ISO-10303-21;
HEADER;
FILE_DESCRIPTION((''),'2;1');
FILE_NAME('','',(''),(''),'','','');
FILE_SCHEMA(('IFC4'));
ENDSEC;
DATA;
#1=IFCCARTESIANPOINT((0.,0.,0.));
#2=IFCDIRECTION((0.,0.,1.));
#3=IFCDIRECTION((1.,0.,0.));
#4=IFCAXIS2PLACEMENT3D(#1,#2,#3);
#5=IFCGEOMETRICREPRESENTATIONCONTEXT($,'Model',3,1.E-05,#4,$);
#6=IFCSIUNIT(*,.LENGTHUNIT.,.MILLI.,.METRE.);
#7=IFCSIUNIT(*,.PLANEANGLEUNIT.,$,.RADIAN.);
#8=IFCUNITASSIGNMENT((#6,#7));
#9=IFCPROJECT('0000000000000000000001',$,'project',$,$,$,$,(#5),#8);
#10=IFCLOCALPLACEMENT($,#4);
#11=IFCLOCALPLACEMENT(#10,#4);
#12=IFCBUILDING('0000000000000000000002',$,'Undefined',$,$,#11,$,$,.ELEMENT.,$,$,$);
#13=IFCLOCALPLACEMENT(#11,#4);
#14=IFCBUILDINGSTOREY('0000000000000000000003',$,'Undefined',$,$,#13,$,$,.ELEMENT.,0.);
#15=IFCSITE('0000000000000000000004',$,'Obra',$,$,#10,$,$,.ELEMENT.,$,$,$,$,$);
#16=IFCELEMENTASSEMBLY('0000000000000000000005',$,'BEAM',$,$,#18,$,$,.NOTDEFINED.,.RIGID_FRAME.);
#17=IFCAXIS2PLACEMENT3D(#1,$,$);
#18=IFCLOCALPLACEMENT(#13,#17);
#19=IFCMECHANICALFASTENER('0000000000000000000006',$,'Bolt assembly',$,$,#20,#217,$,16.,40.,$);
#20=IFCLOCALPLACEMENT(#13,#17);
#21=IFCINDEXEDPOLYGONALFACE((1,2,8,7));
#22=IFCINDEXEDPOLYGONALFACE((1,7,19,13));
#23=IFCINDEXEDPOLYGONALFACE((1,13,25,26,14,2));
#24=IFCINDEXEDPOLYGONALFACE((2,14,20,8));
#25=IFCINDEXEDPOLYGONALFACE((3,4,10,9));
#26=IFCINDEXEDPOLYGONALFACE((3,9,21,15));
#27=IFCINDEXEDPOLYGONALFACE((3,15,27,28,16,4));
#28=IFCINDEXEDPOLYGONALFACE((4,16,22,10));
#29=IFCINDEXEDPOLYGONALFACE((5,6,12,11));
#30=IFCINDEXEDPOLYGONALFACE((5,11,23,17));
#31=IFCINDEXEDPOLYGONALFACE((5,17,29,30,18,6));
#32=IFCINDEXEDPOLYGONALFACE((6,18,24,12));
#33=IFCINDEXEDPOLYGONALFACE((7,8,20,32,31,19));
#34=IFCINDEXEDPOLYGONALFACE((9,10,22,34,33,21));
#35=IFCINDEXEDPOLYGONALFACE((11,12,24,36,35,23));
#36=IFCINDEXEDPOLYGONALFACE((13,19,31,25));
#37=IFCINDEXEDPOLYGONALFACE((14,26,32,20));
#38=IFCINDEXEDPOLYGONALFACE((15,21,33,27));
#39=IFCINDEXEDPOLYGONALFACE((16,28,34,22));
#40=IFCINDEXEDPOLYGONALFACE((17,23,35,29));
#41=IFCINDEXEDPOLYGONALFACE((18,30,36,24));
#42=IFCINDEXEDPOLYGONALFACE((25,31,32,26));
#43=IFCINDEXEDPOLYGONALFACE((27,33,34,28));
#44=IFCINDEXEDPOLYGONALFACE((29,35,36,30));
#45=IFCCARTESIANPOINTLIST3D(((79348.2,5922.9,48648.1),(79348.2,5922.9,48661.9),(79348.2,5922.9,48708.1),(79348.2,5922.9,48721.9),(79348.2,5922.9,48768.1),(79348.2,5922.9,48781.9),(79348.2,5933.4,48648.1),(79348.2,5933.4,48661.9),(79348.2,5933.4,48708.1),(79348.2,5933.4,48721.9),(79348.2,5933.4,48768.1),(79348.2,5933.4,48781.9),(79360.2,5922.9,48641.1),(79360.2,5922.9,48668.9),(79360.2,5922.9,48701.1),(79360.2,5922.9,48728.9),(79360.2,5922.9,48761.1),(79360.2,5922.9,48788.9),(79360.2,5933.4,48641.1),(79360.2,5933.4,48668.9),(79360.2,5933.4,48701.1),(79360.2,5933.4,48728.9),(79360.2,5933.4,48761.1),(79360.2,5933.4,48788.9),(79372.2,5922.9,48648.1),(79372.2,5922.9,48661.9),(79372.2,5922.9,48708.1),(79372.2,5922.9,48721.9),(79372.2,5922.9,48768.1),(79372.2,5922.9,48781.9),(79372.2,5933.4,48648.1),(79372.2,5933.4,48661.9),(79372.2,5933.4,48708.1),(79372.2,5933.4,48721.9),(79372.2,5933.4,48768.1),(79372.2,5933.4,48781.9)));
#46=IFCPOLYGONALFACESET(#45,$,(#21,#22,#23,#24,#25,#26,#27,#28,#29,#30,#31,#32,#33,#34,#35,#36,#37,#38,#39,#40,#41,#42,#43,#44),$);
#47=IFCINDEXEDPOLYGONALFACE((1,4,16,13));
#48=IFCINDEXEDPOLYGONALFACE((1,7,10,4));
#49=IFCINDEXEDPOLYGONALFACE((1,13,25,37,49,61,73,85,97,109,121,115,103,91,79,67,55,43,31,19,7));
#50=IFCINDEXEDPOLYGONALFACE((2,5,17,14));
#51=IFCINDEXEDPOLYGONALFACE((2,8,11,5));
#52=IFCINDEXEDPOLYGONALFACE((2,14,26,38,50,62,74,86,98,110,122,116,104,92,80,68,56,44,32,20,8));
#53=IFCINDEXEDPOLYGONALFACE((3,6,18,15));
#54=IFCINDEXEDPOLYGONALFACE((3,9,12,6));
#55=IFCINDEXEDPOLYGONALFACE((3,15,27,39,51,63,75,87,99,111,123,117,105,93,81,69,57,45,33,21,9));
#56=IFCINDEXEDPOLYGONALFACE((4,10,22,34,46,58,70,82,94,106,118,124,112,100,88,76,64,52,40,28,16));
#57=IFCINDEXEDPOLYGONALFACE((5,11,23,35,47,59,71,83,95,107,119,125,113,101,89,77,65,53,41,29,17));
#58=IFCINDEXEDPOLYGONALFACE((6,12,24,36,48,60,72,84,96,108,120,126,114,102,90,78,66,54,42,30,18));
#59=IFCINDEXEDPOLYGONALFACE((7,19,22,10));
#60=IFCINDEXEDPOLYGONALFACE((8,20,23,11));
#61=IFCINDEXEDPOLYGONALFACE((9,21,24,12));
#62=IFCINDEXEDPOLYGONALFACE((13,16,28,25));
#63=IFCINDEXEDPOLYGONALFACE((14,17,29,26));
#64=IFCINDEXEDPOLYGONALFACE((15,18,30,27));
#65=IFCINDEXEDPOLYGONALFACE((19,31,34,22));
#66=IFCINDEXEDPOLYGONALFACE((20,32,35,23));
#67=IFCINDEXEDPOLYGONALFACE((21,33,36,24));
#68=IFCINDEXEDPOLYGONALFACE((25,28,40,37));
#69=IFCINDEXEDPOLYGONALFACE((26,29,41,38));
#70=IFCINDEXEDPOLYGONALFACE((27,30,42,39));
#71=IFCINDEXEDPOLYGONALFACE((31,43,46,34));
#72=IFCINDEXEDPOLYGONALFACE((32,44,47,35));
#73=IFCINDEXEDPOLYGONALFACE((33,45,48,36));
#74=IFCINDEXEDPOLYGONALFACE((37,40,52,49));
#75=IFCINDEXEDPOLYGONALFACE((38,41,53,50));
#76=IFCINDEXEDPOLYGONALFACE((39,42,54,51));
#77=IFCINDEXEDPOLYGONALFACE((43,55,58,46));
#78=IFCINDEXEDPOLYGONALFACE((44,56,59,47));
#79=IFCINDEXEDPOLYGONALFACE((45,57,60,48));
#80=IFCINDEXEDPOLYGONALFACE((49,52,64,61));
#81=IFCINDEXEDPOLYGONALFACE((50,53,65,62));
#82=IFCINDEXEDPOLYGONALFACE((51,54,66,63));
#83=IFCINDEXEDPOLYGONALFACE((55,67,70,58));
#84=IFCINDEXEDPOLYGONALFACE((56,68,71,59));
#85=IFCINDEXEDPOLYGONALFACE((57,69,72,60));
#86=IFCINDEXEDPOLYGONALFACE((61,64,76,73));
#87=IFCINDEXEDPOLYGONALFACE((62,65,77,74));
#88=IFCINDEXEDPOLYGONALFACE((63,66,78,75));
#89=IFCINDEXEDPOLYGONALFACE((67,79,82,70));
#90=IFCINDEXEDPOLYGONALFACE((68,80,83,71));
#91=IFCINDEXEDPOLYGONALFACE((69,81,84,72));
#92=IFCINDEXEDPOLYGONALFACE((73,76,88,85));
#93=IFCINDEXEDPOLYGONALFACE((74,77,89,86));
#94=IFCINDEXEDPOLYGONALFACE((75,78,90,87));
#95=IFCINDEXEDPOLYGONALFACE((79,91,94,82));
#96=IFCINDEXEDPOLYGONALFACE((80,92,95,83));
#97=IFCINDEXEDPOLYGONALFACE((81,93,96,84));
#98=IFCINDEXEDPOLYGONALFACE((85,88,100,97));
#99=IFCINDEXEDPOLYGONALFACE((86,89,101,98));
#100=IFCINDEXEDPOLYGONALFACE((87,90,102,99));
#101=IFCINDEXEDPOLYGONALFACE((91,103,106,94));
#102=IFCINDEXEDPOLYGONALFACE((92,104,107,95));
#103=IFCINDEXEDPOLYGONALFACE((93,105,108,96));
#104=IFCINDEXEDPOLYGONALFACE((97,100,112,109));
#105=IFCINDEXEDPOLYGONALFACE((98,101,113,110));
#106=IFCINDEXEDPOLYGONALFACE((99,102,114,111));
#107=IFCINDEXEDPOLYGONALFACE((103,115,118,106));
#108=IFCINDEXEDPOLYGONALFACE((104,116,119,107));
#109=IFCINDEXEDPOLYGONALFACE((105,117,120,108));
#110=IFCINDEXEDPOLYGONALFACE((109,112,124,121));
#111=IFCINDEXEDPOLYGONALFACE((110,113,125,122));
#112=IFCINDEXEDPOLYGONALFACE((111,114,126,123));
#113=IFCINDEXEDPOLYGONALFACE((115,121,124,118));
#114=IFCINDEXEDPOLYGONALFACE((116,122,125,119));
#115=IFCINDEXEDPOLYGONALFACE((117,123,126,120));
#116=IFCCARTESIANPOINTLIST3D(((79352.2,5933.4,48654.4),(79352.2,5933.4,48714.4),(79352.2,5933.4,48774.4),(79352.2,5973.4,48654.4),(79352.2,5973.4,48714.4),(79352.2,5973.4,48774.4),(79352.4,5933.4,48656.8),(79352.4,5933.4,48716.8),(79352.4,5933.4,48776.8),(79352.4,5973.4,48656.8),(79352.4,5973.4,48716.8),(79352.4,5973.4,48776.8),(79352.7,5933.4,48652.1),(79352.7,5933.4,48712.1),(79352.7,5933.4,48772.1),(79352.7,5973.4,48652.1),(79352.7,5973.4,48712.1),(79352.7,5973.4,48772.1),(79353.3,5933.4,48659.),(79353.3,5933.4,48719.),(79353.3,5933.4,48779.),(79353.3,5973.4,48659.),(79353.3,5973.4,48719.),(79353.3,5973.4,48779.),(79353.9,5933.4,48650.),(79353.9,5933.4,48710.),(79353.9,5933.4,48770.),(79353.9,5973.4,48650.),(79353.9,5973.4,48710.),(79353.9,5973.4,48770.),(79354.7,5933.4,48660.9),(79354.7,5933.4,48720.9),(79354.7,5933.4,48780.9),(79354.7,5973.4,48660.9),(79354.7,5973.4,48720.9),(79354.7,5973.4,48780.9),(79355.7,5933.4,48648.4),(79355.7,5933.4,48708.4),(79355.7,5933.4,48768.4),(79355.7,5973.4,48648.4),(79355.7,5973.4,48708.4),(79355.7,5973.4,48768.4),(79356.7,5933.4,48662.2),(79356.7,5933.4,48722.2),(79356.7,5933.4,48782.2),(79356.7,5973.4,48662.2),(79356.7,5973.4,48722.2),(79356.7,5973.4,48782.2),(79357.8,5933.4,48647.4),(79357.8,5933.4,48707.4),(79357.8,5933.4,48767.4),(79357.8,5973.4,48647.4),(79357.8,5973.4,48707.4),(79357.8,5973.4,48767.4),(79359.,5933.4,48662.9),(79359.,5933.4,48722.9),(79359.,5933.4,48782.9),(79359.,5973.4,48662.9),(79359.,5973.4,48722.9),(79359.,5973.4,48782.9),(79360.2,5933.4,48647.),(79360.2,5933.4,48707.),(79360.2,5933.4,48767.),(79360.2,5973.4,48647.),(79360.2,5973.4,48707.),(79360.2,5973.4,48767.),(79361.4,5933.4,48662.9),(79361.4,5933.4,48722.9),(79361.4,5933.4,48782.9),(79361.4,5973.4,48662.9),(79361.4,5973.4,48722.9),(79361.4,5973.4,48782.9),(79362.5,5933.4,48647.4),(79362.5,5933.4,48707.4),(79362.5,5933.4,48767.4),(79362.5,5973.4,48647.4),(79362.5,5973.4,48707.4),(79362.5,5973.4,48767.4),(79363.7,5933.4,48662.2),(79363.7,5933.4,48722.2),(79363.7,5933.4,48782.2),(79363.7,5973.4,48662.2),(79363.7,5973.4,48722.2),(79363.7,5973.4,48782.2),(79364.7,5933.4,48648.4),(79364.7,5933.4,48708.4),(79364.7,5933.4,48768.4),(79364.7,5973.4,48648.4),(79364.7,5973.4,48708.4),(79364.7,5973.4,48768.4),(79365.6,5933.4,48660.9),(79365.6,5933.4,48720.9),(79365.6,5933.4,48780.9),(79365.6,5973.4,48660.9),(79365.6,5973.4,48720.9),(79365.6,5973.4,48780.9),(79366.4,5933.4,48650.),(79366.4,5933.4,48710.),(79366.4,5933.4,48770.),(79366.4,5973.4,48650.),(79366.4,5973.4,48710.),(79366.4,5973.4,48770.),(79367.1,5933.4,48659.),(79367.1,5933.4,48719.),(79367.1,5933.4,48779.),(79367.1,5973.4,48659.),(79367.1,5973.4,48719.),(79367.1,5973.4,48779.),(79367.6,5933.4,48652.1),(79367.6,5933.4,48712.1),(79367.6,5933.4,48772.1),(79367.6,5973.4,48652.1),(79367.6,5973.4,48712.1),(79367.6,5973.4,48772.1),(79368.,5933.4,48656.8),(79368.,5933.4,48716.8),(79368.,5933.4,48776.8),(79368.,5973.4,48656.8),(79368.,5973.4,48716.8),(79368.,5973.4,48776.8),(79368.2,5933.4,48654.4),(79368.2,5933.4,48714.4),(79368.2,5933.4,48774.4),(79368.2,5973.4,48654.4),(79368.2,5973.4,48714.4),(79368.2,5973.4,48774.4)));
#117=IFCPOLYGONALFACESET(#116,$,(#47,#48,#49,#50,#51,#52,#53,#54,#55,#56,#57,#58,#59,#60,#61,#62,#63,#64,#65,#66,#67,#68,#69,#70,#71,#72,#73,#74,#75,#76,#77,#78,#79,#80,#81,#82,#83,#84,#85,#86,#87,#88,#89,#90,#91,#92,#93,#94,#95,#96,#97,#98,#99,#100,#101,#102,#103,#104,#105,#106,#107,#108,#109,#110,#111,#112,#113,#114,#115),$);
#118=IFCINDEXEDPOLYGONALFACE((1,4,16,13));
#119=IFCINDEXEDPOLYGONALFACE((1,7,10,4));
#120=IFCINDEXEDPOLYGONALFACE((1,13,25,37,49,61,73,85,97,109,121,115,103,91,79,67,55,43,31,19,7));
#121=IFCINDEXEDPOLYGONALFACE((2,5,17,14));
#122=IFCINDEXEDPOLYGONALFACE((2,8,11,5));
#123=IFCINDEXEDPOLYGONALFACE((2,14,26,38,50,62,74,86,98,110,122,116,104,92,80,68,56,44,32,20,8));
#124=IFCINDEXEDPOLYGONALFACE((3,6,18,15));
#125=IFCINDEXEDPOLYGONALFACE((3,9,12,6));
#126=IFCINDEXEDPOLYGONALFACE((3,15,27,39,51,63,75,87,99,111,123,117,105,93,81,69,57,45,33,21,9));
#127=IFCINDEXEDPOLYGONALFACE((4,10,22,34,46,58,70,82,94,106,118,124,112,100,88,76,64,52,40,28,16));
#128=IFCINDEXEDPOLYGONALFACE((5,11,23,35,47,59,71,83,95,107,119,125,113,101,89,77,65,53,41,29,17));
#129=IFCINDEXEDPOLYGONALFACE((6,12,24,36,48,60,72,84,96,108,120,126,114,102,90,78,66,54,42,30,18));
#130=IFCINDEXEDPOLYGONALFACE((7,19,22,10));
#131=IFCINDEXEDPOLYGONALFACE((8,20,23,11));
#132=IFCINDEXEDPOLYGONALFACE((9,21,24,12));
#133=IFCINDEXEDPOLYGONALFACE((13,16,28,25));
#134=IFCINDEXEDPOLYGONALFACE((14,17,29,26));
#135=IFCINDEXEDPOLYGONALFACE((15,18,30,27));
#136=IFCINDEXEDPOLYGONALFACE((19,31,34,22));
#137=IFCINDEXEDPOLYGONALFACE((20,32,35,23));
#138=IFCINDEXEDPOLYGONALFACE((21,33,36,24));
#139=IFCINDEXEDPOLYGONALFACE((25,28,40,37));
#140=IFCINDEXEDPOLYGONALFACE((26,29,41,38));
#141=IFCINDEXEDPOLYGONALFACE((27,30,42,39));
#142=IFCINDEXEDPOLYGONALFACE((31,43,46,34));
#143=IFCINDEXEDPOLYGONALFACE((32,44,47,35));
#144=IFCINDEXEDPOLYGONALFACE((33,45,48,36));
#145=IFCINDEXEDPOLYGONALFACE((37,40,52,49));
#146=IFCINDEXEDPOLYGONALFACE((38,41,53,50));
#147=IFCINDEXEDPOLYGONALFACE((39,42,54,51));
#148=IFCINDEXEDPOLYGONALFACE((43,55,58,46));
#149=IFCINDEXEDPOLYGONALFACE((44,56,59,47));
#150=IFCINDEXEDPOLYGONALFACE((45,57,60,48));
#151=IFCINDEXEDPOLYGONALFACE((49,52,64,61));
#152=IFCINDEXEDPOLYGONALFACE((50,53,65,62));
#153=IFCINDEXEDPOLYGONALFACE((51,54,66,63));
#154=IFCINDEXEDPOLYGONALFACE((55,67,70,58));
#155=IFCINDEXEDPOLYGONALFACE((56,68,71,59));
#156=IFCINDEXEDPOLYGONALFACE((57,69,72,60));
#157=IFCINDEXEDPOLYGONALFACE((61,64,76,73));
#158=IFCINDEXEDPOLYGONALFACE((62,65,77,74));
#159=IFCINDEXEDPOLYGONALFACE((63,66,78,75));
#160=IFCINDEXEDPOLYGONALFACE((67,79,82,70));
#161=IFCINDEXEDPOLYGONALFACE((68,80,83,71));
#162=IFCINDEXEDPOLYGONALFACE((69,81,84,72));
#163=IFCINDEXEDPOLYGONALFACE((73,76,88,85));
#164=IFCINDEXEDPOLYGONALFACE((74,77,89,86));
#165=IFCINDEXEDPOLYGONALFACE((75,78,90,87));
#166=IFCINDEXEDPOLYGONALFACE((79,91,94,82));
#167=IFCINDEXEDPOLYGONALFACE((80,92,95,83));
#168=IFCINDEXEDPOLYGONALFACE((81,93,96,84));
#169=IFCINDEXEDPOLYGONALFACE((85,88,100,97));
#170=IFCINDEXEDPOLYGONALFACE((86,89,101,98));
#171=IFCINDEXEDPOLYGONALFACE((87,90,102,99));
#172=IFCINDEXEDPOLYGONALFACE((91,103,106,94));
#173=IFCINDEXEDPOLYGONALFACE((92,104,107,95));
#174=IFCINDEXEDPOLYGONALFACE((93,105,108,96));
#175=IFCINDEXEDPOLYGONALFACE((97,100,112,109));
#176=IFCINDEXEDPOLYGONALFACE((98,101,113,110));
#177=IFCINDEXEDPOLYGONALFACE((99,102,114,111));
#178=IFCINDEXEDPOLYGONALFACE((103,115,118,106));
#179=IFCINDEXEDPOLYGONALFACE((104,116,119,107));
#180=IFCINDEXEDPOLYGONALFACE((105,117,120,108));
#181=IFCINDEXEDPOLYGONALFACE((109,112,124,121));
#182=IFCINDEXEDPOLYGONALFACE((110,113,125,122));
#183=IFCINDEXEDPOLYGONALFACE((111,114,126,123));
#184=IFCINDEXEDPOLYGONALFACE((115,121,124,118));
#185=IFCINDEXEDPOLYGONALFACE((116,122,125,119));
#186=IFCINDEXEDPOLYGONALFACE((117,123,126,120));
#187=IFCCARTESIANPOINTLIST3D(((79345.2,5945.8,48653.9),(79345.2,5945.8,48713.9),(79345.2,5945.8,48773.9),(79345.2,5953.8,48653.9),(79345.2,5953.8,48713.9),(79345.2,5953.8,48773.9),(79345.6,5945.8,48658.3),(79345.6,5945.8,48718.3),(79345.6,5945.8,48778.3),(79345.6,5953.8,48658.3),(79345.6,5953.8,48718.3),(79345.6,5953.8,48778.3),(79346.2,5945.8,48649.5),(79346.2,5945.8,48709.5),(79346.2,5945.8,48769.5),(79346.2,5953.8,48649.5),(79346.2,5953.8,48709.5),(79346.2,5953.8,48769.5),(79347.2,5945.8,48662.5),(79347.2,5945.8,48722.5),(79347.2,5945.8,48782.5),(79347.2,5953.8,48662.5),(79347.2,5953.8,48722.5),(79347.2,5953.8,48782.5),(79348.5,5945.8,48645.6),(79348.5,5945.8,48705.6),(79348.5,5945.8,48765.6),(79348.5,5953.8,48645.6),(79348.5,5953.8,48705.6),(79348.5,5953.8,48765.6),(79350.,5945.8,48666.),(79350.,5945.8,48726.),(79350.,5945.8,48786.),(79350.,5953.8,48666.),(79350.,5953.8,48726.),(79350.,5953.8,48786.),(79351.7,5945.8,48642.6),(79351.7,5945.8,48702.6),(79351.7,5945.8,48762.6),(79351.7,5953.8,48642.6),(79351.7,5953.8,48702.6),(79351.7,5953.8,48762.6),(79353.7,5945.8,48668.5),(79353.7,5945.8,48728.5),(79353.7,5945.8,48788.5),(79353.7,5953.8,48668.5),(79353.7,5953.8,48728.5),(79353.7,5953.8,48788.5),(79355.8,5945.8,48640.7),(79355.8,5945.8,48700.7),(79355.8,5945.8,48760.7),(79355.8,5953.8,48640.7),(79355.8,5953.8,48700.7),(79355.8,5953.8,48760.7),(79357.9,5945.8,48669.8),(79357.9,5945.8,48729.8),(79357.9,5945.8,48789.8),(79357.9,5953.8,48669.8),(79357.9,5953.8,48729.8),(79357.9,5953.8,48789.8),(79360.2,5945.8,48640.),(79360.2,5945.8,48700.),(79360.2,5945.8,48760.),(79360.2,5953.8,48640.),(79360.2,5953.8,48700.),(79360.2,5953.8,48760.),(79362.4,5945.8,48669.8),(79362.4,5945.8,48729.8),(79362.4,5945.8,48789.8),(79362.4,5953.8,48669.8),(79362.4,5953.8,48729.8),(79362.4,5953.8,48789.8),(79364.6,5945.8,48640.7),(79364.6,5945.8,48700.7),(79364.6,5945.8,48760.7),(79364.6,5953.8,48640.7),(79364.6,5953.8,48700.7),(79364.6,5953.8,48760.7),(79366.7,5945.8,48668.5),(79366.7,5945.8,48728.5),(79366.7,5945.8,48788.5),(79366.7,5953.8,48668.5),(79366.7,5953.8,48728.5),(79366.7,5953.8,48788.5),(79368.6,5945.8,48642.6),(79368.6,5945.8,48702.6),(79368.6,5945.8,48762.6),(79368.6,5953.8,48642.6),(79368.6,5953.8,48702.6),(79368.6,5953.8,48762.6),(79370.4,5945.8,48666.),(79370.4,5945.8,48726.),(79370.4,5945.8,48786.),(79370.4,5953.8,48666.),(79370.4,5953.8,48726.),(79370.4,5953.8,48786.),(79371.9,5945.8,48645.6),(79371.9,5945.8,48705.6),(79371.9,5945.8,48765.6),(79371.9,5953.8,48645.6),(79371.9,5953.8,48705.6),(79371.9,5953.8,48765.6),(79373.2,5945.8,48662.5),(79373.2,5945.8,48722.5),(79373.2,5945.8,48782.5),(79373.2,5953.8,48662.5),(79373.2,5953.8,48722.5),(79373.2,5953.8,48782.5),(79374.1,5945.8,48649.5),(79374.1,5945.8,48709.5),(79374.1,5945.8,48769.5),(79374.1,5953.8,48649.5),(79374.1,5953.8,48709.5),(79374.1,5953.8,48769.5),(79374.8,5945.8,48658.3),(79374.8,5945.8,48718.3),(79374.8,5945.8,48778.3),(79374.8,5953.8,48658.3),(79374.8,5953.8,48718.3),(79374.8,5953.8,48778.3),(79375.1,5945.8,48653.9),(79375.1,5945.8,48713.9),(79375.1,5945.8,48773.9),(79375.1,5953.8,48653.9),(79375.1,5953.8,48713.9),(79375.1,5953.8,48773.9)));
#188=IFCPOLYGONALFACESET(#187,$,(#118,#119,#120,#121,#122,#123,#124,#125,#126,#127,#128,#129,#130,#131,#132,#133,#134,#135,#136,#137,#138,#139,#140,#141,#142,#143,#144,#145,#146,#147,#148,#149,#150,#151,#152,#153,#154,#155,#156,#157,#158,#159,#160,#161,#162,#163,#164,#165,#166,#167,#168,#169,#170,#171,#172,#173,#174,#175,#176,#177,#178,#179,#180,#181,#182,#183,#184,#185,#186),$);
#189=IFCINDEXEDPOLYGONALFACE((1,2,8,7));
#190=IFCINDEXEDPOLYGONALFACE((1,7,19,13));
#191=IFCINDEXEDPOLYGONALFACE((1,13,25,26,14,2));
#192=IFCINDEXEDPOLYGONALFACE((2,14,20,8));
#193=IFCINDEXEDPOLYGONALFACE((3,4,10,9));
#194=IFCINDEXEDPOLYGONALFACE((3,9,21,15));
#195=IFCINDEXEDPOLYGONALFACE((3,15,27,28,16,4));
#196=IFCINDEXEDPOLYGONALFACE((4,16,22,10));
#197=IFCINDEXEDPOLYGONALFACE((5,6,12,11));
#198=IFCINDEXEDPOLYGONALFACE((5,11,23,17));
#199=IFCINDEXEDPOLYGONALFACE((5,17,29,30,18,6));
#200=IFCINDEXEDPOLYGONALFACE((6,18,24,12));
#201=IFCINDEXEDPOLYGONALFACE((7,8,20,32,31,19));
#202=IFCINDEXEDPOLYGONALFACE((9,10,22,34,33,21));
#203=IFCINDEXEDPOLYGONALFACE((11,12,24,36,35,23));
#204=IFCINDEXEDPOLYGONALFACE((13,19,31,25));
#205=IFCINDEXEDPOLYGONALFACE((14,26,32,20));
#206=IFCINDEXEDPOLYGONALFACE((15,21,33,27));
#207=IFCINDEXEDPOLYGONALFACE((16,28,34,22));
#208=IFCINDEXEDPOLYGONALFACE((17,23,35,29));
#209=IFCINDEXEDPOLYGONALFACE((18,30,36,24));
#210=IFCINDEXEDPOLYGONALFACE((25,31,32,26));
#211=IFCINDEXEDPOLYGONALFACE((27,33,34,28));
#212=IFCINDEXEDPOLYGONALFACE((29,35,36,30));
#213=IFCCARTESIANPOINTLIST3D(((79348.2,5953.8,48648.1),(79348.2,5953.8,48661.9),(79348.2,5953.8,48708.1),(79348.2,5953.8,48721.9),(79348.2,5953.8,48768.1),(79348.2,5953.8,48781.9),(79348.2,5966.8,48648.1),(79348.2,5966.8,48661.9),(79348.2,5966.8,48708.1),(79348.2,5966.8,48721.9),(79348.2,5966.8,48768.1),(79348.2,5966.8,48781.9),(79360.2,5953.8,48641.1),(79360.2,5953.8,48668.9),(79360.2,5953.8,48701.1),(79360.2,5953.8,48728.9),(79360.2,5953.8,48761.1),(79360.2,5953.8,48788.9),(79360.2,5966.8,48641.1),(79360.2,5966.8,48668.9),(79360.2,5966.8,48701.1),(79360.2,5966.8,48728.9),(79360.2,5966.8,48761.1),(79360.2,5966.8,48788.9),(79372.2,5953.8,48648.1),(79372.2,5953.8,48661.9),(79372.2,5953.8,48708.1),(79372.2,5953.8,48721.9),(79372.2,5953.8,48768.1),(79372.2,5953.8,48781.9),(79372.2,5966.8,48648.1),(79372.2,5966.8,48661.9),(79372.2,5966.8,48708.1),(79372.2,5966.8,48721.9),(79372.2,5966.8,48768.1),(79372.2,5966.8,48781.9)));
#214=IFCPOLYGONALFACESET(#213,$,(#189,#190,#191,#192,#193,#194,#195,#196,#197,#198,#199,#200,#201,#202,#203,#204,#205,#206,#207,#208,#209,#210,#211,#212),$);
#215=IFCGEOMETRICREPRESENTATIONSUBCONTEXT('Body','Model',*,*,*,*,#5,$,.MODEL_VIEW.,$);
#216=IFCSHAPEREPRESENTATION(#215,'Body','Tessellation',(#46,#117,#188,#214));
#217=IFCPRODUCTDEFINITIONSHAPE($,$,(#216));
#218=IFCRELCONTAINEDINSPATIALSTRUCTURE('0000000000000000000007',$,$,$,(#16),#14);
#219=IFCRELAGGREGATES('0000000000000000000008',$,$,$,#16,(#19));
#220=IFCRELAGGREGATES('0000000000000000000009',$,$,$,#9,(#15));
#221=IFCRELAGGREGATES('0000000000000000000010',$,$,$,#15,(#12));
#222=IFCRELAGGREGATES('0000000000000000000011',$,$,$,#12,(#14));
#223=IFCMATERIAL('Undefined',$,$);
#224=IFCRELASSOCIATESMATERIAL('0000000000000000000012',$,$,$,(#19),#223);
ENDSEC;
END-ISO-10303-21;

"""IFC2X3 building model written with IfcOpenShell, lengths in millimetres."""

from ifc_helpers import new_model, si_unit, frame, origin_with_axes, origin_2d_with_axis, place, context, subcontext, project, spatial, polyline, circle, outline, extrude, source, transform, mapped, material, element, aggregate, save


model = new_model("IFC2X3")

# Units and contexts
model_context = context("Model", 3, precision=1e-05, world=origin_with_axes())
body_context = subcontext(model_context, "Body", "Model", "MODEL_VIEW")
ifc_project = project(units=[si_unit("LENGTHUNIT", "METRE", prefix="MILLI"), si_unit("PLANEANGLEUNIT", "RADIAN")], contexts=[model_context])

# Site, building, storey
site_placement = place(None, origin_with_axes())
site = spatial("IfcSite", under=ifc_project, at=site_placement, Name="Obra", CompositionType="ELEMENT")
building_placement = place(site_placement, origin_with_axes())
building = spatial("IfcBuilding", under=site, at=building_placement, Name="Undefined", CompositionType="ELEMENT")
storey_placement = place(building_placement, origin_with_axes())
storey = spatial("IfcBuildingStorey", under=building, at=storey_placement, Name="Undefined", CompositionType="ELEMENT", Elevation=0.0)

# Element assembly
assembly_1_placement = place(storey_placement, origin_with_axes())
assembly_1 = element("IfcElementAssembly", 1, at=assembly_1_placement, inside=storey, Name="BEAM", AssemblyPlace="NOTDEFINED", PredefinedType="RIGID_FRAME")

# Mechanical fastener
ifc_material_1 = material(Name="Undefined")
shared_shape_1 = source(origin_with_axes(), body_context, "Body", "SweptSolid", [
    extrude(outline(polyline([(13.9, 0.0), (6.9, 12.0), (-6.9, 12.0), (-13.9, 0.0), (-6.9, -12.0), (6.9, -12.0), (13.9, 0.0)])), frame((0.0, -19.7, 0.0), z_axis=(0.0, 1.0, 0.0), x_axis=(1.0, 0.0, 0.0)), (0.0, 0.0, 1.0), 10.6),
    extrude(circle(Radius=8.0, at=origin_2d_with_axis()), frame((0.0, -9.1, 0.0), z_axis=(0.0, 1.0, 0.0), x_axis=(1.0, 0.0, 0.0)), (0.0, 0.0, 1.0), 40.0),
    extrude(circle(Radius=15.0, at=origin_2d_with_axis()), frame((0.0, 3.3, 0.0), z_axis=(0.0, 1.0, 0.0), x_axis=(1.0, 0.0, 0.0)), (0.0, 0.0, 1.0), 8.0),
    extrude(outline(polyline([(13.9, 0.0), (6.9, 12.0), (-6.9, 12.0), (-13.9, 0.0), (-6.9, -12.0), (6.9, -12.0), (13.9, 0.0)])), frame((0.0, 11.3, 0.0), z_axis=(0.0, 1.0, 0.0), x_axis=(1.0, 0.0, 0.0)), (0.0, 0.0, 1.0), 13.0),
])
mechanical_fastener_placement = place(assembly_1_placement, frame((79310.2, 5942.5, 48835.0), z_axis=(1.0, 0.0, 0.0), x_axis=(0.0, 0.0, -1.0)))
mechanical_fastener = element("IfcMechanicalFastener", 2, at=mechanical_fastener_placement, material=ifc_material_1, Name="Bolt assembly", NominalDiameter=16.0, NominalLength=40.0, context=body_context, shape_type="MappedRepresentation", body=[
    mapped(shared_shape_1, transform((60.0, 0.0, 50.0))),
    mapped(shared_shape_1, transform((120.0, 0.0, 50.0))),
    mapped(shared_shape_1, transform((180.0, 0.0, 50.0))),
])
aggregate(assembly_1, [mechanical_fastener])

save(model, "model.ifc")
